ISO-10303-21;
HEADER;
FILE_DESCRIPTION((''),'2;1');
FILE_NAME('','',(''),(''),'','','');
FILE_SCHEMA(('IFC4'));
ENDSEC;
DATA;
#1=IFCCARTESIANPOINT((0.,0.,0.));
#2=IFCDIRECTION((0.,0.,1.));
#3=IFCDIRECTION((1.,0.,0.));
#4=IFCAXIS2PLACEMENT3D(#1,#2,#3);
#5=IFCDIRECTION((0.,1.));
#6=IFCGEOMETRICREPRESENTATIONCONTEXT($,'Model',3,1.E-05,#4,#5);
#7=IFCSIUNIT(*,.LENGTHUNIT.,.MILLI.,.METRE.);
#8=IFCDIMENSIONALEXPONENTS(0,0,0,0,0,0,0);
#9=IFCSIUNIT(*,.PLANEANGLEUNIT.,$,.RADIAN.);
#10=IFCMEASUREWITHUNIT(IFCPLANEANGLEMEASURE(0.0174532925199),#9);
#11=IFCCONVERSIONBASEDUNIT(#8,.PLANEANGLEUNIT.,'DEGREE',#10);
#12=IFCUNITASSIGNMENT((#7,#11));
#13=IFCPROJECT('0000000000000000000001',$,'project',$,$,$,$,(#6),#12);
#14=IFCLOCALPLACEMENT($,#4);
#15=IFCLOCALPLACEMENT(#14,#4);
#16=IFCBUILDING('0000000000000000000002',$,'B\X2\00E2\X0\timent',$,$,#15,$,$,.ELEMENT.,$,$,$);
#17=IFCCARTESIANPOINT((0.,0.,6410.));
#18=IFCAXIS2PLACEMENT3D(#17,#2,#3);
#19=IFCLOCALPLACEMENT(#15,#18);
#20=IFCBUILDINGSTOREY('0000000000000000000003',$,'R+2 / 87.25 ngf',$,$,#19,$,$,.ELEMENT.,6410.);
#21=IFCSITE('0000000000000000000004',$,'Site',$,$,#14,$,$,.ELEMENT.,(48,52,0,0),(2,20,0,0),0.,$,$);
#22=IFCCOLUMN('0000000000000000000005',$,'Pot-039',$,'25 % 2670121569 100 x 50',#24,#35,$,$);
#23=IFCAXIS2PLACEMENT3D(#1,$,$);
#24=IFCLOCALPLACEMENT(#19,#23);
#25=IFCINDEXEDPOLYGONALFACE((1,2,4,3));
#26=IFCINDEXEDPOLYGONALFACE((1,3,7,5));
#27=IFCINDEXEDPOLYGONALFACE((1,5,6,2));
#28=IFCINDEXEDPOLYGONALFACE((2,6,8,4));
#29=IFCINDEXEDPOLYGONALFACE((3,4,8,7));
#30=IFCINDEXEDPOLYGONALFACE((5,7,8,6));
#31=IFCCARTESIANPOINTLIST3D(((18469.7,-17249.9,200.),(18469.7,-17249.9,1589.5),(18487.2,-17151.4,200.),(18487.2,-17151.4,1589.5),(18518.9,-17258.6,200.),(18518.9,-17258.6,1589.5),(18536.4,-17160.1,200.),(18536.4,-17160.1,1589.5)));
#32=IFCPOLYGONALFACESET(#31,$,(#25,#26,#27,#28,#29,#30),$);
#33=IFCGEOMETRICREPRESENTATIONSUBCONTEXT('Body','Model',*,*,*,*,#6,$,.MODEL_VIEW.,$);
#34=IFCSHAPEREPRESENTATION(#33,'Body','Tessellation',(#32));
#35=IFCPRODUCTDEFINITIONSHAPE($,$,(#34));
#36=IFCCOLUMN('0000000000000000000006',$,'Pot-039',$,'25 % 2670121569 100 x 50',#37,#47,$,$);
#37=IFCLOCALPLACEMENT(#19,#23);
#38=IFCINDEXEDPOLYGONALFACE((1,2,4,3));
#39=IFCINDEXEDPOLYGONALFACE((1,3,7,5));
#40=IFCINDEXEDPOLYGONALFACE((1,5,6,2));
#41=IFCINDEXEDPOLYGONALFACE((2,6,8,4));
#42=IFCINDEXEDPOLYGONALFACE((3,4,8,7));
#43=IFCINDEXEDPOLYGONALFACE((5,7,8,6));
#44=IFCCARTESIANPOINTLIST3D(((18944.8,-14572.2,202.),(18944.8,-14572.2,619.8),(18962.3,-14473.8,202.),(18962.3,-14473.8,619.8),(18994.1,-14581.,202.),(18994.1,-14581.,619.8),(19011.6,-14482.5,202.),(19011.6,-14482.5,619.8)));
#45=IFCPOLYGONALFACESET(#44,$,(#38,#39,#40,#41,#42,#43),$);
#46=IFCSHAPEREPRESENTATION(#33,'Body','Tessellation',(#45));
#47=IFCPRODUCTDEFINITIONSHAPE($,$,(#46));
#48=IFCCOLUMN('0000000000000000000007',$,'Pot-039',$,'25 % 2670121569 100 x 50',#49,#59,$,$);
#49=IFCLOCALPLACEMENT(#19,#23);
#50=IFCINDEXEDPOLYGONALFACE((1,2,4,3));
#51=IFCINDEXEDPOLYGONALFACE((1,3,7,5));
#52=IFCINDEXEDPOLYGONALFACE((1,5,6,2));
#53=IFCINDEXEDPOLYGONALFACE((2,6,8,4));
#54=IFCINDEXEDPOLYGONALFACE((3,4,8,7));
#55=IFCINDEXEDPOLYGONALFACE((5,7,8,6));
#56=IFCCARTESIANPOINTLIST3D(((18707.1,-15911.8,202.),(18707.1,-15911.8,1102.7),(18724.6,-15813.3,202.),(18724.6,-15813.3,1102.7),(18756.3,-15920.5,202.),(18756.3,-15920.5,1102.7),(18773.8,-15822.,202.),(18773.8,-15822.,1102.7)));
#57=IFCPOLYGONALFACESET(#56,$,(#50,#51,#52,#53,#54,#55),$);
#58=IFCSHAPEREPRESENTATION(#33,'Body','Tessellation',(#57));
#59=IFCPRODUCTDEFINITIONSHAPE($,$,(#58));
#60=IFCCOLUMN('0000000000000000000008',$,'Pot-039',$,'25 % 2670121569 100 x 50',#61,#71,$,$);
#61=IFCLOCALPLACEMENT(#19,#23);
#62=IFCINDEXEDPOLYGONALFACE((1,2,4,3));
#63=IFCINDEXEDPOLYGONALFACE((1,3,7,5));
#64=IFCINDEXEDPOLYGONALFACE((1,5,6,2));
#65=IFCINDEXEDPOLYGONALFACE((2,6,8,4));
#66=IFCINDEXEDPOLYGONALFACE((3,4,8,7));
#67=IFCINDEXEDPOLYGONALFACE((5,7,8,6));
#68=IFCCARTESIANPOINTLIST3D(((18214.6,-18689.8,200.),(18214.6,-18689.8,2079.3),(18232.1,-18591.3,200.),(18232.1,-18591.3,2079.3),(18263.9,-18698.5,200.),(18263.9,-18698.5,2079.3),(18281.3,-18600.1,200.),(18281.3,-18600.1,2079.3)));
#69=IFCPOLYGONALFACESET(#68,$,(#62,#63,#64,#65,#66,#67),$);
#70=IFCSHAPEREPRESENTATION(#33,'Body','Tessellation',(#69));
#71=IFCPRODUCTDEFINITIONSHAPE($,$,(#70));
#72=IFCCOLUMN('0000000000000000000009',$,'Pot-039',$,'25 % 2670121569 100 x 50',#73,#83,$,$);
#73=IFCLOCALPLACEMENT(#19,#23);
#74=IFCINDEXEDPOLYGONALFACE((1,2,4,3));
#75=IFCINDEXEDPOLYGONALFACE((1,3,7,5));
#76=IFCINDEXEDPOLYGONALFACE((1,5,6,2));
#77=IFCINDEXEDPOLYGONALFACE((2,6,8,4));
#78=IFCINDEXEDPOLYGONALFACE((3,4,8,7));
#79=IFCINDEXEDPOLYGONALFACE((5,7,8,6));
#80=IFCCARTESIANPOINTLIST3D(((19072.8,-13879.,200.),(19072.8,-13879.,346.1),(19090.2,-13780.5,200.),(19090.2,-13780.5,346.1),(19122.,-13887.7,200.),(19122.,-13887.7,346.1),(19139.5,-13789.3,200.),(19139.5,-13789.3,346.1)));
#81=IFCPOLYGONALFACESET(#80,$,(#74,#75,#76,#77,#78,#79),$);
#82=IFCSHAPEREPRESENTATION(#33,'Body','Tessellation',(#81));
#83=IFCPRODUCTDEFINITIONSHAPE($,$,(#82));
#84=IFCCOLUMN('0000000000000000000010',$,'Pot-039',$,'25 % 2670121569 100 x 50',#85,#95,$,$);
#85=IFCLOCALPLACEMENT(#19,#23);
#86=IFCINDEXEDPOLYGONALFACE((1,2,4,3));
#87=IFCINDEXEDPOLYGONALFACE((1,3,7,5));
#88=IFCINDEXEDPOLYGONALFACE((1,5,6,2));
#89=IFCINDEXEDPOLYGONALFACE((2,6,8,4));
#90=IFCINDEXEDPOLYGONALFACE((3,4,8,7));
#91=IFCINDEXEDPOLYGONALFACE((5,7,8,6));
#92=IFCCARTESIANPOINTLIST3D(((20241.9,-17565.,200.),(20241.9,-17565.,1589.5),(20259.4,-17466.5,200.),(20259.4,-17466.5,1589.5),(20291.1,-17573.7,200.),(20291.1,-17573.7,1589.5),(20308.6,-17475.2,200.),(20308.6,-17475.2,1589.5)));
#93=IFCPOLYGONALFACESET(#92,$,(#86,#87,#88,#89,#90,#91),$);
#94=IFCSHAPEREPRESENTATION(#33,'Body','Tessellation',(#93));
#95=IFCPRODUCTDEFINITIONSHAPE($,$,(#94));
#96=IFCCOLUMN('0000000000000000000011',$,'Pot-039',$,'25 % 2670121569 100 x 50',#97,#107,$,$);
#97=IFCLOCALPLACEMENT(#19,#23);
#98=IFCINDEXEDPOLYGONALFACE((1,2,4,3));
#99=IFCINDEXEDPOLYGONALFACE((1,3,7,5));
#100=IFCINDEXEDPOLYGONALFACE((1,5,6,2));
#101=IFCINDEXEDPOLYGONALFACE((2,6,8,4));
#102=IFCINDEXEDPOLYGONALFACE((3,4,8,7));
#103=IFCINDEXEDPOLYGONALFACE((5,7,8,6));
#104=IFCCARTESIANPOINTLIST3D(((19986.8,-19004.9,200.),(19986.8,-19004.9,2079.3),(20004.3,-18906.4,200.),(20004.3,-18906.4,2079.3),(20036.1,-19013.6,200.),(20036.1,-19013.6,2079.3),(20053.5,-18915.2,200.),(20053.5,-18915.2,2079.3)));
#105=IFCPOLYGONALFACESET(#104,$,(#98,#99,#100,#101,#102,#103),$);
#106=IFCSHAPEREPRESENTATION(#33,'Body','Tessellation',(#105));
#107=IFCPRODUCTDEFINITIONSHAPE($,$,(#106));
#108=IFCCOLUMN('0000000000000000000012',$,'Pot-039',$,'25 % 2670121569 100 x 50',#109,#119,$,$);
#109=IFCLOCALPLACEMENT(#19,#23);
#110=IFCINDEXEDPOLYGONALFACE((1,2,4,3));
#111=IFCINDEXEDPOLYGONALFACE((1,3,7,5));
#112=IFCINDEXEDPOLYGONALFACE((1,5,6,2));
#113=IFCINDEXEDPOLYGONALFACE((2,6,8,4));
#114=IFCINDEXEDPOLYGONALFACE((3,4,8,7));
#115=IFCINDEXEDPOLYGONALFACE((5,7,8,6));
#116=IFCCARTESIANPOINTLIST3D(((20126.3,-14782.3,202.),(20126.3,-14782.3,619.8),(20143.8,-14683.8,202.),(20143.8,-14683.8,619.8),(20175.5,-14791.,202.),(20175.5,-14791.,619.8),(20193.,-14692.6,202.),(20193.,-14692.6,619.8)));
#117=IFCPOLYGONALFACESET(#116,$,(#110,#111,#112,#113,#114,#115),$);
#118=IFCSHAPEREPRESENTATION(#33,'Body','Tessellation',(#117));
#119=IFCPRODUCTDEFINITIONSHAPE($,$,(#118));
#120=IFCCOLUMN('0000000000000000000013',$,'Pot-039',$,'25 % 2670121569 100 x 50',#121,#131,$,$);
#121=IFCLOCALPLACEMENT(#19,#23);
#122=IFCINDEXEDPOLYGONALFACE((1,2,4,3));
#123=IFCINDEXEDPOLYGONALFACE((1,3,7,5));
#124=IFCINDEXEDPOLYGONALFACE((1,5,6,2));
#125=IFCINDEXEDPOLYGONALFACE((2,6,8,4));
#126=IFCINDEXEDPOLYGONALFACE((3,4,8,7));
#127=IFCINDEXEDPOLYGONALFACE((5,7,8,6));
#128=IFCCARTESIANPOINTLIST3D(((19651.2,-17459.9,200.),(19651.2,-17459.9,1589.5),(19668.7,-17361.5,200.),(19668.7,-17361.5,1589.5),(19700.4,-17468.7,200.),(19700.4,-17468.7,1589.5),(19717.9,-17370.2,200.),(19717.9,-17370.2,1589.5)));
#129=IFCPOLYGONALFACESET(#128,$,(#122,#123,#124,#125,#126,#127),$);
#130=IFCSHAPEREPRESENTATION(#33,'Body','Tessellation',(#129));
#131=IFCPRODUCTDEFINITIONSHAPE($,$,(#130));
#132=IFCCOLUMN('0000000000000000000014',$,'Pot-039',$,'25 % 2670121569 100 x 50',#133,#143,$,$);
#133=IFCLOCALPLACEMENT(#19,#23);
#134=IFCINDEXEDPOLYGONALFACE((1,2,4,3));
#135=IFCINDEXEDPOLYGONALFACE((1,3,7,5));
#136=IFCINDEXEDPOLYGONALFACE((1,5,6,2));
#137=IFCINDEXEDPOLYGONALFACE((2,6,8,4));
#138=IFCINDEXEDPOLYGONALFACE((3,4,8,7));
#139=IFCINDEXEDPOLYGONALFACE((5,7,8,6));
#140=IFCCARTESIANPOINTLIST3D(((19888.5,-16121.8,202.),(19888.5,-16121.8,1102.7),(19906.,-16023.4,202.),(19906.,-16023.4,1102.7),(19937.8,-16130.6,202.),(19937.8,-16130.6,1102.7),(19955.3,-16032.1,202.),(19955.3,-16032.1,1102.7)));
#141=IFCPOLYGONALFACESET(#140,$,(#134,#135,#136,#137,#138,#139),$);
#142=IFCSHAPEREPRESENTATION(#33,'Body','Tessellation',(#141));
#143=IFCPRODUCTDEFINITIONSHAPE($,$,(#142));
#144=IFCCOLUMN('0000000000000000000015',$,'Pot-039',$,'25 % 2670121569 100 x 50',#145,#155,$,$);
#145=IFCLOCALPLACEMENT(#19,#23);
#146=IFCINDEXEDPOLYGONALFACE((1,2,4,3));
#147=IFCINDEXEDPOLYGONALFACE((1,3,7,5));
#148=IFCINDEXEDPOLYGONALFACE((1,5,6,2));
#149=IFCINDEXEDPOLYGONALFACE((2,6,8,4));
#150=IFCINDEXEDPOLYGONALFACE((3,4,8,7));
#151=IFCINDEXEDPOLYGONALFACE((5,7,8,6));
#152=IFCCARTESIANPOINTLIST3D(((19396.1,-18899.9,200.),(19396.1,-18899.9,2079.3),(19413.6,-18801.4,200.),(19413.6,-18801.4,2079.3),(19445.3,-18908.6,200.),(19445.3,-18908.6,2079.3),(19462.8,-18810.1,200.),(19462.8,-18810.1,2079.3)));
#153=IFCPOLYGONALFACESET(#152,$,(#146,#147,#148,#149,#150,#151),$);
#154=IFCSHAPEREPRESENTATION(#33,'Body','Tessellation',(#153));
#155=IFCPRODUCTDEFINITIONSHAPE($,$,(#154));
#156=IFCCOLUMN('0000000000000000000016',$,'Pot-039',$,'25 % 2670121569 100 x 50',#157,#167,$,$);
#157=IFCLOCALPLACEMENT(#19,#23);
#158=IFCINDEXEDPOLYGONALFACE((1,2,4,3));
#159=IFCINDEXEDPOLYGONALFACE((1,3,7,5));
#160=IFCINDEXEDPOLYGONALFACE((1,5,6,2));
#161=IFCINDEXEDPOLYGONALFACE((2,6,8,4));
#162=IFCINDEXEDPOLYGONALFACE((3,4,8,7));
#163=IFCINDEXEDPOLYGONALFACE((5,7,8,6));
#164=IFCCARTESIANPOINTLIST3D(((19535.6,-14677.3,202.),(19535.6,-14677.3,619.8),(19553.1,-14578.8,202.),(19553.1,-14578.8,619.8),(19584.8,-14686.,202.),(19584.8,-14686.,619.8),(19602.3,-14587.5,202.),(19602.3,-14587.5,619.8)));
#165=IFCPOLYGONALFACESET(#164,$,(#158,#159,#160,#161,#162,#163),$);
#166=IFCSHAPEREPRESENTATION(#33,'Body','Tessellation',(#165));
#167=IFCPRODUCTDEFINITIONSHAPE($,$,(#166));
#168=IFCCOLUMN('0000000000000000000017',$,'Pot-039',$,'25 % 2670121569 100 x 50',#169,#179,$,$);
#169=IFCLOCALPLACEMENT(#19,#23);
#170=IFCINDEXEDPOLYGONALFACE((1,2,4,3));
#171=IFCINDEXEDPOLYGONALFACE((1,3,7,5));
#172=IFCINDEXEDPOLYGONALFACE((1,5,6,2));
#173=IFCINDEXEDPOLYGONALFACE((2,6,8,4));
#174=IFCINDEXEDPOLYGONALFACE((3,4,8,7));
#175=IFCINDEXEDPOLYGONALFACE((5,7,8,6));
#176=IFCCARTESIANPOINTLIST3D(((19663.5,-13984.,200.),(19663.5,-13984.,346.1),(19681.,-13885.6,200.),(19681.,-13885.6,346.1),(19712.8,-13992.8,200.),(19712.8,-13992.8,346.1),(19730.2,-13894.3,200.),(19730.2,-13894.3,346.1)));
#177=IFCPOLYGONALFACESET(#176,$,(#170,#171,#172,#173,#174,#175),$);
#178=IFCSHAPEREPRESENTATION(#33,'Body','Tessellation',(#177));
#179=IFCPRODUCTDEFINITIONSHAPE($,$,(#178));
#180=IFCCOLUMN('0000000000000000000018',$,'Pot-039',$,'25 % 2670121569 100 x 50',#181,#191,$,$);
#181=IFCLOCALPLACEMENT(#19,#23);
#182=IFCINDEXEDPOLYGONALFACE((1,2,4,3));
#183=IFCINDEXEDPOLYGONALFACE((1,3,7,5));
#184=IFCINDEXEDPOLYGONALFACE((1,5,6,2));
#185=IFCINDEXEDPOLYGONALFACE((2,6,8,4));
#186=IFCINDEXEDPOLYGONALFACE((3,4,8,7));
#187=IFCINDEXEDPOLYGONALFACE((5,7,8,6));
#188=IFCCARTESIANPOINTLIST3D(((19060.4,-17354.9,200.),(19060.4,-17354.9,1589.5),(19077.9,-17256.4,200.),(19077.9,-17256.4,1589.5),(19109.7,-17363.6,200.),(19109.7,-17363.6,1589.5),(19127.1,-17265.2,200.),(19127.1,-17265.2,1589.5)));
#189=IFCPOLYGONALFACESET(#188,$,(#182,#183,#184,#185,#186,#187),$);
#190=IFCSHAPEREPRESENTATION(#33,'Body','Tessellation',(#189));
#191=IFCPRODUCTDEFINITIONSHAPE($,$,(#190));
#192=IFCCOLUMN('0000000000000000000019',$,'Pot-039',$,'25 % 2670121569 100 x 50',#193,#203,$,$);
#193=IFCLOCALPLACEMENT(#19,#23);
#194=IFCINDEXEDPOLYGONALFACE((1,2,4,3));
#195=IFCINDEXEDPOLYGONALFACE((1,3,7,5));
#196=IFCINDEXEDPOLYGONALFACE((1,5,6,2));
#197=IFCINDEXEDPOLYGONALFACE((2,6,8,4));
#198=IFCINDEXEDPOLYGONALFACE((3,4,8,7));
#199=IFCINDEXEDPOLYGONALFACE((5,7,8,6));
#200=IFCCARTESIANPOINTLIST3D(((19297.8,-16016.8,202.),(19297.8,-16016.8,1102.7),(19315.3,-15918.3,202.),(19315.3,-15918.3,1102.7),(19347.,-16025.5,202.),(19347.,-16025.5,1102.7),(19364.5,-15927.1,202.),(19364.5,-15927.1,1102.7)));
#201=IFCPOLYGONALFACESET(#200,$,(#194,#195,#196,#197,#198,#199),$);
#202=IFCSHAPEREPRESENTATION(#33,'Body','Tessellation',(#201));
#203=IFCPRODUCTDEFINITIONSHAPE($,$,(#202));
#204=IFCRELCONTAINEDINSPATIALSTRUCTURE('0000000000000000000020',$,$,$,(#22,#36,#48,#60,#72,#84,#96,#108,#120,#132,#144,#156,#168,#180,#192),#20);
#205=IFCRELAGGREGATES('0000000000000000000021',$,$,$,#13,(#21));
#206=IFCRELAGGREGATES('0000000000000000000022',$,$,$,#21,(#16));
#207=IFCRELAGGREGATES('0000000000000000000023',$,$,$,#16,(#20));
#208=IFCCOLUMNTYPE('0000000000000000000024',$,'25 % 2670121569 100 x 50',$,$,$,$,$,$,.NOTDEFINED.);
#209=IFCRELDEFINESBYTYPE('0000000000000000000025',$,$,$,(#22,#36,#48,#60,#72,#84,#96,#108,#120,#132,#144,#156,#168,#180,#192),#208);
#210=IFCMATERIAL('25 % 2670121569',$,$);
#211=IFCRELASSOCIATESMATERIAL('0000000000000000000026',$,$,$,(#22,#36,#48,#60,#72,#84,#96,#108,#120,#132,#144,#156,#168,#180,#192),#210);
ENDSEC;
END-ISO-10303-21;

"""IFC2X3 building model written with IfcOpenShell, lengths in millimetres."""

from ifc_helpers import new_model, entity, si_unit, converted_unit, direction, frame, origin_with_axes, origin_2d_with_axis, place, context, subcontext, project, spatial, rectangle, extrude, material, type_object, element, save


model = new_model("IFC2X3")

# Units and contexts
model_context = context("Model", 3, precision=1e-05, world=origin_with_axes(), true_north=direction((0.0, 1.0)))
body_context = subcontext(model_context, "Body", "Model", "MODEL_VIEW")
ifc_project = project(units=[si_unit("LENGTHUNIT", "METRE", prefix="MILLI"), converted_unit("PLANEANGLEUNIT", "DEGREE", entity("IfcPlaneAngleMeasure", 0.0174532925199), si_unit("PLANEANGLEUNIT", "RADIAN"), dimensions=[0, 0, 0, 0, 0, 0, 0])], contexts=[model_context])

# Site, building, storey
site_placement = place(None, origin_with_axes())
site = spatial("IfcSite", under=ifc_project, at=site_placement, Name="Site", CompositionType="ELEMENT", RefLatitude=(48, 52, 0, 0), RefLongitude=(2, 20, 0, 0), RefElevation=0.0)
building_placement = place(site_placement, origin_with_axes())
building = spatial("IfcBuilding", under=site, at=building_placement, Name="Bâtiment", CompositionType="ELEMENT")
storey_placement = place(building_placement, frame((0.0, 0.0, 6410.0), z_axis=(0.0, 0.0, 1.0), x_axis=(1.0, 0.0, 0.0)))
storey = spatial("IfcBuildingStorey", under=building, at=storey_placement, Name="R+2 / 87.25 ngf", CompositionType="ELEMENT", Elevation=6410.0)

# Columns
ifc_material_1 = material(Name="25 % 2670121569")
column_type = type_object("IfcColumnType", Name="25 % 2670121569 100 x 50", PredefinedType="NOTDEFINED")
column_1_placement = place(storey_placement, frame((18503.1, -17205.0, 200.0), z_axis=(0.0, 0.0, 1.0), x_axis=(0.17478, 0.984607, 0.0)))
element("IfcColumn", 1, at=column_1_placement, inside=storey, type_object=column_type, material=ifc_material_1, Name="Pot-039", ObjectType="25 % 2670121569 100 x 50", context=body_context, shape_type="SweptSolid", body=[
    extrude(rectangle(XDim=100.0, YDim=50.0, at=origin_2d_with_axis()), origin_with_axes(), (0.0, 0.0, 1.0), 1389.5),
])
column_2_placement = place(storey_placement, frame((18978.2, -14527.4, 202.0), z_axis=(0.0, 0.0, 1.0), x_axis=(0.17478, 0.984607, 0.0)))
element("IfcColumn", 2, at=column_2_placement, inside=storey, type_object=column_type, material=ifc_material_1, Name="Pot-039", ObjectType="25 % 2670121569 100 x 50", context=body_context, shape_type="SweptSolid", body=[
    extrude(rectangle(XDim=100.0, YDim=50.0, at=origin_2d_with_axis()), origin_with_axes(), (0.0, 0.0, 1.0), 417.8),
])
column_3_placement = place(storey_placement, frame((18740.4, -15866.9, 202.0), z_axis=(0.0, 0.0, 1.0), x_axis=(0.17478, 0.984607, 0.0)))
element("IfcColumn", 3, at=column_3_placement, inside=storey, type_object=column_type, material=ifc_material_1, Name="Pot-039", ObjectType="25 % 2670121569 100 x 50", context=body_context, shape_type="SweptSolid", body=[
    extrude(rectangle(XDim=100.0, YDim=50.0, at=origin_2d_with_axis()), origin_with_axes(), (0.0, 0.0, 1.0), 900.7),
])
column_4_placement = place(storey_placement, frame((18248.0, -18644.9, 200.0), z_axis=(0.0, 0.0, 1.0), x_axis=(0.17478, 0.984607, 0.0)))
element("IfcColumn", 4, at=column_4_placement, inside=storey, type_object=column_type, material=ifc_material_1, Name="Pot-039", ObjectType="25 % 2670121569 100 x 50", context=body_context, shape_type="SweptSolid", body=[
    extrude(rectangle(XDim=100.0, YDim=50.0, at=origin_2d_with_axis()), origin_with_axes(), (0.0, 0.0, 1.0), 1879.3),
])
column_5_placement = place(storey_placement, frame((19106.1, -13834.1, 200.0), z_axis=(0.0, 0.0, 1.0), x_axis=(0.174407, 0.984674, 0.0)))
element("IfcColumn", 5, at=column_5_placement, inside=storey, type_object=column_type, material=ifc_material_1, Name="Pot-039", ObjectType="25 % 2670121569 100 x 50", context=body_context, shape_type="SweptSolid", body=[
    extrude(rectangle(XDim=100.0, YDim=50.0, at=origin_2d_with_axis()), origin_with_axes(), (0.0, 0.0, 1.0), 146.1),
])
column_6_placement = place(storey_placement, frame((20275.3, -17520.1, 200.0), z_axis=(0.0, 0.0, 1.0), x_axis=(0.17478, 0.984607, 0.0)))
element("IfcColumn", 6, at=column_6_placement, inside=storey, type_object=column_type, material=ifc_material_1, Name="Pot-039", ObjectType="25 % 2670121569 100 x 50", context=body_context, shape_type="SweptSolid", body=[
    extrude(rectangle(XDim=100.0, YDim=50.0, at=origin_2d_with_axis()), origin_with_axes(), (0.0, 0.0, 1.0), 1389.5),
])
column_7_placement = place(storey_placement, frame((20020.2, -18960.0, 200.0), z_axis=(0.0, 0.0, 1.0), x_axis=(0.17478, 0.984607, 0.0)))
element("IfcColumn", 7, at=column_7_placement, inside=storey, type_object=column_type, material=ifc_material_1, Name="Pot-039", ObjectType="25 % 2670121569 100 x 50", context=body_context, shape_type="SweptSolid", body=[
    extrude(rectangle(XDim=100.0, YDim=50.0, at=origin_2d_with_axis()), origin_with_axes(), (0.0, 0.0, 1.0), 1879.3),
])
column_8_placement = place(storey_placement, frame((20159.7, -14737.4, 202.0), z_axis=(0.0, 0.0, 1.0), x_axis=(0.17478, 0.984607, 0.0)))
element("IfcColumn", 8, at=column_8_placement, inside=storey, type_object=column_type, material=ifc_material_1, Name="Pot-039", ObjectType="25 % 2670121569 100 x 50", context=body_context, shape_type="SweptSolid", body=[
    extrude(rectangle(XDim=100.0, YDim=50.0, at=origin_2d_with_axis()), origin_with_axes(), (0.0, 0.0, 1.0), 417.8),
])
column_9_placement = place(storey_placement, frame((19684.5, -17415.1, 200.0), z_axis=(0.0, 0.0, 1.0), x_axis=(0.17478, 0.984607, 0.0)))
element("IfcColumn", 9, at=column_9_placement, inside=storey, type_object=column_type, material=ifc_material_1, Name="Pot-039", ObjectType="25 % 2670121569 100 x 50", context=body_context, shape_type="SweptSolid", body=[
    extrude(rectangle(XDim=100.0, YDim=50.0, at=origin_2d_with_axis()), origin_with_axes(), (0.0, 0.0, 1.0), 1389.5),
])
column_10_placement = place(storey_placement, frame((19921.9, -16077.0, 202.0), z_axis=(0.0, 0.0, 1.0), x_axis=(0.17478, 0.984607, 0.0)))
element("IfcColumn", 10, at=column_10_placement, inside=storey, type_object=column_type, material=ifc_material_1, Name="Pot-039", ObjectType="25 % 2670121569 100 x 50", context=body_context, shape_type="SweptSolid", body=[
    extrude(rectangle(XDim=100.0, YDim=50.0, at=origin_2d_with_axis()), origin_with_axes(), (0.0, 0.0, 1.0), 900.7),
])
column_11_placement = place(storey_placement, frame((19429.5, -18855.0, 200.0), z_axis=(0.0, 0.0, 1.0), x_axis=(0.17478, 0.984607, 0.0)))
element("IfcColumn", 11, at=column_11_placement, inside=storey, type_object=column_type, material=ifc_material_1, Name="Pot-039", ObjectType="25 % 2670121569 100 x 50", context=body_context, shape_type="SweptSolid", body=[
    extrude(rectangle(XDim=100.0, YDim=50.0, at=origin_2d_with_axis()), origin_with_axes(), (0.0, 0.0, 1.0), 1879.3),
])
column_12_placement = place(storey_placement, frame((19568.9, -14632.4, 202.0), z_axis=(0.0, 0.0, 1.0), x_axis=(0.17478, 0.984607, 0.0)))
element("IfcColumn", 12, at=column_12_placement, inside=storey, type_object=column_type, material=ifc_material_1, Name="Pot-039", ObjectType="25 % 2670121569 100 x 50", context=body_context, shape_type="SweptSolid", body=[
    extrude(rectangle(XDim=100.0, YDim=50.0, at=origin_2d_with_axis()), origin_with_axes(), (0.0, 0.0, 1.0), 417.8),
])
column_13_placement = place(storey_placement, frame((19696.9, -13939.2, 200.0), z_axis=(0.0, 0.0, 1.0), x_axis=(0.174407, 0.984674, 0.0)))
element("IfcColumn", 13, at=column_13_placement, inside=storey, type_object=column_type, material=ifc_material_1, Name="Pot-039", ObjectType="25 % 2670121569 100 x 50", context=body_context, shape_type="SweptSolid", body=[
    extrude(rectangle(XDim=100.0, YDim=50.0, at=origin_2d_with_axis()), origin_with_axes(), (0.0, 0.0, 1.0), 146.1),
])
column_14_placement = place(storey_placement, frame((19093.8, -17310.0, 200.0), z_axis=(0.0, 0.0, 1.0), x_axis=(0.17478, 0.984607, 0.0)))
element("IfcColumn", 14, at=column_14_placement, inside=storey, type_object=column_type, material=ifc_material_1, Name="Pot-039", ObjectType="25 % 2670121569 100 x 50", context=body_context, shape_type="SweptSolid", body=[
    extrude(rectangle(XDim=100.0, YDim=50.0, at=origin_2d_with_axis()), origin_with_axes(), (0.0, 0.0, 1.0), 1389.5),
])
column_15_placement = place(storey_placement, frame((19331.2, -15971.9, 202.0), z_axis=(0.0, 0.0, 1.0), x_axis=(0.17478, 0.984607, 0.0)))
element("IfcColumn", 15, at=column_15_placement, inside=storey, type_object=column_type, material=ifc_material_1, Name="Pot-039", ObjectType="25 % 2670121569 100 x 50", context=body_context, shape_type="SweptSolid", body=[
    extrude(rectangle(XDim=100.0, YDim=50.0, at=origin_2d_with_axis()), origin_with_axes(), (0.0, 0.0, 1.0), 900.7),
])

save(model, "model.ifc")
